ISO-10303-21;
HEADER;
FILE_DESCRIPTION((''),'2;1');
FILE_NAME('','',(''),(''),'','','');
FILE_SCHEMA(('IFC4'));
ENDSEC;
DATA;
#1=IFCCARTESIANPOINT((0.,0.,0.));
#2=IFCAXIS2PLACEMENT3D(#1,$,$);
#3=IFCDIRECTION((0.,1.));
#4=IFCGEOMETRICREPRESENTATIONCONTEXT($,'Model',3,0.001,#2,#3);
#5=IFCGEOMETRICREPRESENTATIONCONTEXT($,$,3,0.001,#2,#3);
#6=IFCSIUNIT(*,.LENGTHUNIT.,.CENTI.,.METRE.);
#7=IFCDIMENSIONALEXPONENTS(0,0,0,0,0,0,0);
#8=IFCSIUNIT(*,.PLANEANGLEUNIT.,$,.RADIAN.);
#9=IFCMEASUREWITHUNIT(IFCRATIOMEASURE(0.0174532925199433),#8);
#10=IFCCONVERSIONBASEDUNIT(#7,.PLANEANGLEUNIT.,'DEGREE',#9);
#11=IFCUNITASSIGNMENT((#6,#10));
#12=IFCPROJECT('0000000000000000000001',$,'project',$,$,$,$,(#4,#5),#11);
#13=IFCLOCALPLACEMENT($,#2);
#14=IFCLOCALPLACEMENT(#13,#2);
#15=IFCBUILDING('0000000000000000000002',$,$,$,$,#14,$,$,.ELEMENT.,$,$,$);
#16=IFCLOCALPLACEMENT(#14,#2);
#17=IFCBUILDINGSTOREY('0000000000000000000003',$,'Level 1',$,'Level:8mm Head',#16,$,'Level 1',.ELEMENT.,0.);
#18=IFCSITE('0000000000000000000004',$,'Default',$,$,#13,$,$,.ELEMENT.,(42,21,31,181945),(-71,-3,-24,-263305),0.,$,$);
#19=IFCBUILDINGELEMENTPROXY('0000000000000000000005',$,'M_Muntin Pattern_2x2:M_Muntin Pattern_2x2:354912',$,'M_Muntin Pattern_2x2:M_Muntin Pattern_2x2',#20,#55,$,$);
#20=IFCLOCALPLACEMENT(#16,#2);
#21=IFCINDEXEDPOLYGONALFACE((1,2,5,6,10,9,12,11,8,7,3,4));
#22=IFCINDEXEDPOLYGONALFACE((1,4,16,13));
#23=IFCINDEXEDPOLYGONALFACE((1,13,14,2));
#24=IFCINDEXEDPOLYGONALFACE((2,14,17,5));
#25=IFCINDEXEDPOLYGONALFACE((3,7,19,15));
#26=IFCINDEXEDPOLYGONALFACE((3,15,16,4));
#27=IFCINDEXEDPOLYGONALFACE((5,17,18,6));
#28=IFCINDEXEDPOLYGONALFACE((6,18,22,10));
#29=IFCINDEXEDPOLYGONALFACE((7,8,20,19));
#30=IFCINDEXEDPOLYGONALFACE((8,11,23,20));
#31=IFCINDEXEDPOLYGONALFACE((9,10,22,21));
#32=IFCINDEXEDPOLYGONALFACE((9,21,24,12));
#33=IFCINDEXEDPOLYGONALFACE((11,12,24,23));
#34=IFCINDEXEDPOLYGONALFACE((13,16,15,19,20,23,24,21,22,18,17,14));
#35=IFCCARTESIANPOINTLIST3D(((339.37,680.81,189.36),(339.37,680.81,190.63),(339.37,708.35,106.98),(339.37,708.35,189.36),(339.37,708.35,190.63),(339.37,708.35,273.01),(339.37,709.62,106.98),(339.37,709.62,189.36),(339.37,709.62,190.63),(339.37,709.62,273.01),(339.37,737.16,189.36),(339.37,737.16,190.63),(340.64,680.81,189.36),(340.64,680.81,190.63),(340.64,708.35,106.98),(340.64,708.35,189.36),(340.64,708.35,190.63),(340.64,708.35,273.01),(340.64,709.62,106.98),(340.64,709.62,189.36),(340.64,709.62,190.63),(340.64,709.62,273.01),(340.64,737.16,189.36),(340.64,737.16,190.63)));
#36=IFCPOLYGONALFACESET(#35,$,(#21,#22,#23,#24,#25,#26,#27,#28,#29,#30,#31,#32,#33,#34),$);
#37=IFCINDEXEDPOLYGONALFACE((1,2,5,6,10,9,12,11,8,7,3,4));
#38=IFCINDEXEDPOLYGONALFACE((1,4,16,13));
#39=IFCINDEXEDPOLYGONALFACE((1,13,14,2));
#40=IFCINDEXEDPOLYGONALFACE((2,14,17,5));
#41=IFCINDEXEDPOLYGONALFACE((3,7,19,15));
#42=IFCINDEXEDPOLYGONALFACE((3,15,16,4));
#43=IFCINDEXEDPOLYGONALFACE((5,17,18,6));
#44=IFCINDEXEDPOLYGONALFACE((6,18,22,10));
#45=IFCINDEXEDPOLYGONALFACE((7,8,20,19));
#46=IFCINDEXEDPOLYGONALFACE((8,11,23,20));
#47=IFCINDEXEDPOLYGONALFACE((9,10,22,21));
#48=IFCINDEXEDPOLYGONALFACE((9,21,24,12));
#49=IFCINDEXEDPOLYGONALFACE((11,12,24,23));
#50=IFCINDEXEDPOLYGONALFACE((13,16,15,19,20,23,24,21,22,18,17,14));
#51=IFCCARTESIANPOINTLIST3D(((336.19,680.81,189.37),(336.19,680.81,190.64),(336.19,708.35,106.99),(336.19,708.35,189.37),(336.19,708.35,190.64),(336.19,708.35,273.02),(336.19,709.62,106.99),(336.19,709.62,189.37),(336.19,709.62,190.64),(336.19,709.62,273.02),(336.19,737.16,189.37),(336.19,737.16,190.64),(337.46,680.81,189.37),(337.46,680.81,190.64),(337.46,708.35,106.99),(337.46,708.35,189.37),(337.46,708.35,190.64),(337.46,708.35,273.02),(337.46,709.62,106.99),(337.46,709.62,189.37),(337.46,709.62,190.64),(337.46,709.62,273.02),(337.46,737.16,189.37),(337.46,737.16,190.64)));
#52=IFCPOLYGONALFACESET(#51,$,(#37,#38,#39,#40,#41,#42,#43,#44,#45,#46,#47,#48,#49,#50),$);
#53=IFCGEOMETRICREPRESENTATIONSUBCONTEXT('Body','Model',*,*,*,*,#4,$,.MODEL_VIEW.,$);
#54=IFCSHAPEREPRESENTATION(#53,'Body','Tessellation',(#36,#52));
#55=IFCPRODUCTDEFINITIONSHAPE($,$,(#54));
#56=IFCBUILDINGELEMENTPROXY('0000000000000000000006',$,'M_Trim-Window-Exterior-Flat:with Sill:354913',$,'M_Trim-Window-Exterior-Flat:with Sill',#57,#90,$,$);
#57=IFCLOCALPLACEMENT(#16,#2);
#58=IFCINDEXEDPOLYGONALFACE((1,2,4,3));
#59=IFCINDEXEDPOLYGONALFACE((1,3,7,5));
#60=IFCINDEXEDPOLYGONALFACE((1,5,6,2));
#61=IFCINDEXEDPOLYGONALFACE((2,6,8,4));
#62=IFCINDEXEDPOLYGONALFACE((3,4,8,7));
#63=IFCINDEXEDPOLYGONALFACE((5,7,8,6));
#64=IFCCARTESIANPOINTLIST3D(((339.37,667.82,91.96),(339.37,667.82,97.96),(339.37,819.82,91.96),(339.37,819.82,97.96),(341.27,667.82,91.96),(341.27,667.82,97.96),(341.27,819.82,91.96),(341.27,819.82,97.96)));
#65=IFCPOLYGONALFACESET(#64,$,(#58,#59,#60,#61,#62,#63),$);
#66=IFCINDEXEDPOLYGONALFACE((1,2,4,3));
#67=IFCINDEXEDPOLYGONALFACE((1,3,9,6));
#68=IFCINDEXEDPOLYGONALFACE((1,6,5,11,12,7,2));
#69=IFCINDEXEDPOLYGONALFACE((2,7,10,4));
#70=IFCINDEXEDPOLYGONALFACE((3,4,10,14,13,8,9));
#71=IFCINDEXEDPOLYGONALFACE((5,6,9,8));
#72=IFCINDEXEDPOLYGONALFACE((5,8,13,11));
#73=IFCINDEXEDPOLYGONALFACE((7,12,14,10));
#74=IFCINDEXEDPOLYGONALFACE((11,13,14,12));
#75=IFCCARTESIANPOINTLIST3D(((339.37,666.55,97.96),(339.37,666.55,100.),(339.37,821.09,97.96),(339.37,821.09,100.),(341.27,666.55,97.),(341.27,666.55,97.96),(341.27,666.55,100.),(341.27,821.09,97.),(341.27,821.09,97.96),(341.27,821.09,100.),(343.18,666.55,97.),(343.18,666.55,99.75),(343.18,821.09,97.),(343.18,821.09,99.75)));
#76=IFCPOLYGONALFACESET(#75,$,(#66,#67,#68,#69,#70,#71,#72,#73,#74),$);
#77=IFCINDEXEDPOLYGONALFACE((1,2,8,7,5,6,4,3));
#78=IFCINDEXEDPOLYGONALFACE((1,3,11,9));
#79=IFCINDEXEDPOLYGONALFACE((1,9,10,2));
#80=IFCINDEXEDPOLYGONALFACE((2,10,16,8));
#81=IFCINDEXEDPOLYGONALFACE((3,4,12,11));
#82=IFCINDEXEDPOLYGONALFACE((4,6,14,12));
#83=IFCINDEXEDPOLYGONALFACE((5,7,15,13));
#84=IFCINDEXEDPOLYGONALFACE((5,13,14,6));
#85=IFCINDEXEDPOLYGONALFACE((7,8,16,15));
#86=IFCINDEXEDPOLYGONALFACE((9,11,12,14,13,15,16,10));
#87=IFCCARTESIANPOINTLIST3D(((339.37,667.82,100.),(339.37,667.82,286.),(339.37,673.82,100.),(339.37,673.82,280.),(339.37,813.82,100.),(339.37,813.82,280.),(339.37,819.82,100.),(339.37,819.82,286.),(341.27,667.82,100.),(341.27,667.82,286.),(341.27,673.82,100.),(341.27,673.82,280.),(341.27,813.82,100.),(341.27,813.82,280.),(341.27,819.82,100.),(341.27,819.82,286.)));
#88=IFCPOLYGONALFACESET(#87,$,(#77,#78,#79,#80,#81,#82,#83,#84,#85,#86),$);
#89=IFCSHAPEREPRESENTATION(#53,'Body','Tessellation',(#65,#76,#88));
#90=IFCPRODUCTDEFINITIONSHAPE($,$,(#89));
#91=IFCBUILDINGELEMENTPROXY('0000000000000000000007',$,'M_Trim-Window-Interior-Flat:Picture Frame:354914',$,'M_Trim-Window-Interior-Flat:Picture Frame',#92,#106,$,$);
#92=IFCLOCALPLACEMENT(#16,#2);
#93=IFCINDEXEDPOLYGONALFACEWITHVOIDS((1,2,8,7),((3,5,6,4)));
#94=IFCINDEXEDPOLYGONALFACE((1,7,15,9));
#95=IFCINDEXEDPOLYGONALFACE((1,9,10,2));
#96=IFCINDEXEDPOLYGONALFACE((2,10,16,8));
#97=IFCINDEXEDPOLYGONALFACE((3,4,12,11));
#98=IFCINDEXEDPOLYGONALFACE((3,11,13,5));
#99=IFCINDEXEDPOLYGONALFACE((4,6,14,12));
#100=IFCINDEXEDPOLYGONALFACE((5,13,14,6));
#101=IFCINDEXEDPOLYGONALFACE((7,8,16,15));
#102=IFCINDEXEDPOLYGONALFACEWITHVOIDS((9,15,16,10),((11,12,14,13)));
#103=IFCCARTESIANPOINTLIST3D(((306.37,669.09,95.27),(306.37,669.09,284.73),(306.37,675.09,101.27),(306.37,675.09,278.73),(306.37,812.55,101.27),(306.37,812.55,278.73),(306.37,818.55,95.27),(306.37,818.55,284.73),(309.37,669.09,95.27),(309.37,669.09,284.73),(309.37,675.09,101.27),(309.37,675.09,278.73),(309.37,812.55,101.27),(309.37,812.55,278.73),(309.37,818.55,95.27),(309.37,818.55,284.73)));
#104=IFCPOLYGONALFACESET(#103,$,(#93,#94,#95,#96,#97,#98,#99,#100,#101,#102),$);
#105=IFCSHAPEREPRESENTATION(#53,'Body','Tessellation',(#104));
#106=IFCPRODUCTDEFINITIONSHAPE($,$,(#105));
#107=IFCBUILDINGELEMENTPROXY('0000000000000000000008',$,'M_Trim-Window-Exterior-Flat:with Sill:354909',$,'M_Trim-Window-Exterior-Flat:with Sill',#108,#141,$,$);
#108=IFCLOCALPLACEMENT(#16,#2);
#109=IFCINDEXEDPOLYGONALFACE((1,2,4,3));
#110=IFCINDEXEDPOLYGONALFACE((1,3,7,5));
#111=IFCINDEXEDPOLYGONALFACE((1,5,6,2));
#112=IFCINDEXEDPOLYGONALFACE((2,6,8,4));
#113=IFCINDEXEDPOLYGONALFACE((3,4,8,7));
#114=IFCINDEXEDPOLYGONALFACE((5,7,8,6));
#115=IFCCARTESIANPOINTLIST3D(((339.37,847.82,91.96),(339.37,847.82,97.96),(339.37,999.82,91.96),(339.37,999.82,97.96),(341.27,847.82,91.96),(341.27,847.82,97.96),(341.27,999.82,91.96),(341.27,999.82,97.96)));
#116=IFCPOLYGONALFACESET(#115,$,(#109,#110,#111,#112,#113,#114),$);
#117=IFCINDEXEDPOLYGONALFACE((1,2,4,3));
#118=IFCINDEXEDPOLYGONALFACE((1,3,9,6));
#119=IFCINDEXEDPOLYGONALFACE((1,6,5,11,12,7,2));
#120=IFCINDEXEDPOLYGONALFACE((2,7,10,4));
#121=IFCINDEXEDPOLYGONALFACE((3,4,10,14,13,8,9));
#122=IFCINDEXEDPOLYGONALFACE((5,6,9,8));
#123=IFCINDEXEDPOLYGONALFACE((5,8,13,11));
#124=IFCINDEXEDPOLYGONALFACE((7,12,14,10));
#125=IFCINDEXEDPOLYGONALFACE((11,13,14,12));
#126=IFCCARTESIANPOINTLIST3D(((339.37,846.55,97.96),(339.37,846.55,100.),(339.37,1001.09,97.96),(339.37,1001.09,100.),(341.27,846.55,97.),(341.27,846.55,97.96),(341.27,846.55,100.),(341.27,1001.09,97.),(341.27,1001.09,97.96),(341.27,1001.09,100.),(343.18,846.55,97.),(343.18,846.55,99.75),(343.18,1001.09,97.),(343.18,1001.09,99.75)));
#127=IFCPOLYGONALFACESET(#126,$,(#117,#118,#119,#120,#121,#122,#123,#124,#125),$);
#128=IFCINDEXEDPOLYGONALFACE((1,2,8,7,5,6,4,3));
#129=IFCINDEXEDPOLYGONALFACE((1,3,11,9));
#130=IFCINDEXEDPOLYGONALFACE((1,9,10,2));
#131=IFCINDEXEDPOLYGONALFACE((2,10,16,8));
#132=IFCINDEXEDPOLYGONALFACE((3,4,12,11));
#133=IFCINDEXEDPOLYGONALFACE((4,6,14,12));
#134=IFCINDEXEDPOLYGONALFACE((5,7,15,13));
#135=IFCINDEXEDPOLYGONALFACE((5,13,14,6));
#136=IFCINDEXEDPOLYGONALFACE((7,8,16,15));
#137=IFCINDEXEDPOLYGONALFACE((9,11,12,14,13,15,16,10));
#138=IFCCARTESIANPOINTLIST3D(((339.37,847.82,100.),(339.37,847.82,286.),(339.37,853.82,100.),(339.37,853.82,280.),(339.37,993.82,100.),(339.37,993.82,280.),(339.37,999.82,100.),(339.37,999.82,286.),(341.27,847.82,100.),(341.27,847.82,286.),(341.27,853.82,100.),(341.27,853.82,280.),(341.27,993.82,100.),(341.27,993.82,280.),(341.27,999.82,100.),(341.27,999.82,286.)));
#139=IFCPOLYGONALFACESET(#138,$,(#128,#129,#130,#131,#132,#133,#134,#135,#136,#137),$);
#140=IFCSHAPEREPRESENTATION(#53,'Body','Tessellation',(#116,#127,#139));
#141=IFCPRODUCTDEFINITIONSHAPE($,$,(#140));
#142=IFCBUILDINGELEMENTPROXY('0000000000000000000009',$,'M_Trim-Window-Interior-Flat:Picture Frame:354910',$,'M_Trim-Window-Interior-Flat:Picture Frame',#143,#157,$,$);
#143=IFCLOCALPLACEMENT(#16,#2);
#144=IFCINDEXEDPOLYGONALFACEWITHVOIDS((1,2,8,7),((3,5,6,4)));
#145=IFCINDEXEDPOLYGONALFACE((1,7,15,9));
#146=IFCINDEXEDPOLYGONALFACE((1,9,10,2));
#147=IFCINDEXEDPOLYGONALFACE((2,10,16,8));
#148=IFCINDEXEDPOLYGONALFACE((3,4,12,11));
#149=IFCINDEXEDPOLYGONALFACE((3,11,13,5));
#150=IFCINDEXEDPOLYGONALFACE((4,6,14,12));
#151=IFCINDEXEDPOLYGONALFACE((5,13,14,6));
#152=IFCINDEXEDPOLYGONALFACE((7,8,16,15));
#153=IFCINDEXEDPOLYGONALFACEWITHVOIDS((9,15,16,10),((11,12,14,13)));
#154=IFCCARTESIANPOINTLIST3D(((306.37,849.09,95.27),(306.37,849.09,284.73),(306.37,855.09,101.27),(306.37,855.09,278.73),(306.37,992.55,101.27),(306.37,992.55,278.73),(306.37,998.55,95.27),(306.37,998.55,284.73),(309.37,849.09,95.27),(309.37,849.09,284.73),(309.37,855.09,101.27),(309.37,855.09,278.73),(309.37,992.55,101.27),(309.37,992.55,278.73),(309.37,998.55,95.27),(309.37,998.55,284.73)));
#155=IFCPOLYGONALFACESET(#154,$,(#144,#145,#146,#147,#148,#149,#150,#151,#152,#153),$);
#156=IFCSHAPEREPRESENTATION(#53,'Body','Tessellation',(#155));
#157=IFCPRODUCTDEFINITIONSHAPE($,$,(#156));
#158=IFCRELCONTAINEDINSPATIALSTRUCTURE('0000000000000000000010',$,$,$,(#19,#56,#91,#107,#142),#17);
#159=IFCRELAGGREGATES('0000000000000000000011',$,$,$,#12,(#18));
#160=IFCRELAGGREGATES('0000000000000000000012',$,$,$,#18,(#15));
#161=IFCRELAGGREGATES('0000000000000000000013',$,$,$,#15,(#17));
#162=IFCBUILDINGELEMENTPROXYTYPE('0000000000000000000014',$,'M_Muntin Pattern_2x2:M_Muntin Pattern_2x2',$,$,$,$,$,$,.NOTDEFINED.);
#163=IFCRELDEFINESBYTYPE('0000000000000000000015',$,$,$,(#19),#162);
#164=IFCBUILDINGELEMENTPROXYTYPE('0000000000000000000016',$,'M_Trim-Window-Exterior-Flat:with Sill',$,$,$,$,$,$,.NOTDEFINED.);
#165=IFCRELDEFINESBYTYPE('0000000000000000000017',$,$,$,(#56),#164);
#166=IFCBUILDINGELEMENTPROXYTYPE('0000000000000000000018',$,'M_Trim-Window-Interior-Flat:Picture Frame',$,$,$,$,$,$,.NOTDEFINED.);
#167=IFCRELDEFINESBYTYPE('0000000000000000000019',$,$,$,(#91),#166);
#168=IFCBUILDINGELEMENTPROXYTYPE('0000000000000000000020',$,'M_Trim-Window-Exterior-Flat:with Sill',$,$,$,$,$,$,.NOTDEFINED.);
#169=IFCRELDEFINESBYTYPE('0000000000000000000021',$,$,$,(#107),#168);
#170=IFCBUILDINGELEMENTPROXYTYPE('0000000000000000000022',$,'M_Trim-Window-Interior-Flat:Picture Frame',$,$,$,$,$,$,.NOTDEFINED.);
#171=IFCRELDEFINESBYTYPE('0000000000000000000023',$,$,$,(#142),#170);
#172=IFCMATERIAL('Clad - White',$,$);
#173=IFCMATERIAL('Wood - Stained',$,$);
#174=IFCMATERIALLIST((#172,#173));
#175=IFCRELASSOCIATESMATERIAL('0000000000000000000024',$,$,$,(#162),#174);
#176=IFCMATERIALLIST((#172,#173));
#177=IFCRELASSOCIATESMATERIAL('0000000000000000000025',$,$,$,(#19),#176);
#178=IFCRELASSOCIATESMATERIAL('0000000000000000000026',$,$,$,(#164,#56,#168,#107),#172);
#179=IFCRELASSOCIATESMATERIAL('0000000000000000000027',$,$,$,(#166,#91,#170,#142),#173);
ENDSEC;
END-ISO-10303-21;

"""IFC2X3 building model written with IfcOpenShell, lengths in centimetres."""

from ifc_helpers import new_model, entity, si_unit, converted_unit, direction, frame, frame_2d, origin, place, context, subcontext, project, spatial, polyline, rectangle, outline, extrude, source, transform, mapped, material, material_list, type_object, type_shapes, element, save


model = new_model("IFC2X3")

# Units and contexts
model_context = context("Model", 3, precision=0.001, world=origin(), true_north=direction((0.0, 1.0)))
context_of_model = context(None, 3, precision=0.001, world=origin(), true_north=direction((0.0, 1.0)))
body_context = subcontext(model_context, "Body", "Model", "MODEL_VIEW")
ifc_project = project(units=[si_unit("LENGTHUNIT", "METRE", prefix="CENTI"), converted_unit("PLANEANGLEUNIT", "DEGREE", entity("IfcRatioMeasure", 0.0174532925199433), si_unit("PLANEANGLEUNIT", "RADIAN"), dimensions=[0, 0, 0, 0, 0, 0, 0])], contexts=[model_context, context_of_model])

# Site, building, storey
site_placement = place(None, origin())
site = spatial("IfcSite", under=ifc_project, at=site_placement, Name="Default", CompositionType="ELEMENT", RefLatitude=(42, 21, 31, 181945), RefLongitude=(-71, -3, -24, -263305), RefElevation=0.0)
building_placement = place(site_placement, origin())
building = spatial("IfcBuilding", under=site, at=building_placement, CompositionType="ELEMENT")
storey_placement = place(building_placement, origin())
storey = spatial("IfcBuildingStorey", under=building, at=storey_placement, Name="Level 1", ObjectType="Level:8mm Head", LongName="Level 1", CompositionType="ELEMENT", Elevation=0.0)

# Shared definitions
ifc_material_1 = material(Name="Wood - Stained")
ifc_material_2 = material(Name="Clad - White")

# Building element proxies
ifc_material_list_1 = material_list([ifc_material_2, ifc_material_1])
building_element_proxy_type_1 = type_object("IfcBuildingElementProxyType", Name="M_Muntin Pattern_2x2:M_Muntin Pattern_2x2", PredefinedType="NOTDEFINED", material=ifc_material_list_1)
shared_shape_1 = source(origin(), body_context, "Body", "SweptSolid", [
    extrude(outline(polyline([(0.64, -0.64), (83.01, -0.64), (83.01, 0.63), (0.64, 0.63), (0.64, 28.17), (-0.63, 28.17), (-0.63, 0.63), (-83.02, 0.63), (-83.02, -0.64), (-0.63, -0.64), (-0.63, -28.17), (0.64, -28.17), (0.64, -0.64)])), frame((0.0, -2.22, 83.01), z_axis=(0.0, 1.0, 0.0), x_axis=(0.0, 0.0, 1.0)), (0.0, 0.0, 1.0), 1.27),
    extrude(outline(polyline([(0.64, -0.64), (83.02, -0.64), (83.02, 0.63), (0.64, 0.63), (0.64, 28.17), (-0.63, 28.17), (-0.63, 0.63), (-83.02, 0.63), (-83.02, -0.64), (-0.63, -0.64), (-0.63, -28.17), (0.64, -28.17), (0.64, -0.64)])), frame((0.0, 0.95, 83.02), z_axis=(0.0, 1.0, 0.0), x_axis=(0.0, 0.0, 1.0)), (0.0, 0.0, 1.0), 1.27),
])
type_shapes(building_element_proxy_type_1, [shared_shape_1])
ifc_material_list_2 = material_list([ifc_material_2, ifc_material_1])
proxy_1_placement = place(storey_placement, frame((338.41, 708.98, 106.99), z_axis=(0.0, 0.0, 1.0), x_axis=(0.0, 1.0, 0.0)))
element("IfcBuildingElementProxy", 1, at=proxy_1_placement, inside=storey, type_object=building_element_proxy_type_1, material=ifc_material_list_2, Name="M_Muntin Pattern_2x2:M_Muntin Pattern_2x2:354912", ObjectType="M_Muntin Pattern_2x2:M_Muntin Pattern_2x2", context=body_context, shape_type="MappedRepresentation", body=[
    mapped(shared_shape_1, transform((0.0, 0.0, 0.0), scale=1.0)),
])
building_element_proxy_type_2 = type_object("IfcBuildingElementProxyType", Name="M_Trim-Window-Exterior-Flat:with Sill", PredefinedType="NOTDEFINED", material=ifc_material_2)
shared_shape_2 = source(origin(), body_context, "Body", "SweptSolid", [
    extrude(rectangle(XDim=152.0, YDim=6.0, at=frame_2d((0.0, 0.0), x_axis=(1.0, 0.0))), frame((0.0, -185.04, 0.0), z_axis=(0.0, 0.0, 1.0), x_axis=(-1.0, 0.0, 0.0)), (0.0, 0.0, 1.0), 1.91),
    extrude(outline(polyline([(-1.9, -1.52), (0.0, -1.52), (0.0, -0.57), (1.9, -0.57), (1.9, 1.48), (0.0, 1.48), (-1.9, 1.23), (-1.9, -1.52)])), frame((-77.27, -181.48, 1.9), z_axis=(1.0, 0.0, 0.0), x_axis=(0.0, 0.0, -1.0)), (0.0, 0.0, 1.0), 154.54),
    extrude(outline(polyline([(-94.5, -76.0), (91.5, -76.0), (91.5, -70.0), (-88.5, -70.0), (-88.5, 70.0), (91.5, 70.0), (91.5, 76.0), (-94.5, 76.0), (-94.5, -76.0)])), frame((0.0, -88.5, 0.0), z_axis=(0.0, 0.0, 1.0), x_axis=(0.0, -1.0, 0.0)), (0.0, 0.0, 1.0), 1.91),
])
type_shapes(building_element_proxy_type_2, [shared_shape_2])
proxy_2_placement = place(storey_placement, frame((339.37, 743.82, 280.0), z_axis=(1.0, 0.0, 0.0), x_axis=(0.0, 1.0, 0.0)))
element("IfcBuildingElementProxy", 2, at=proxy_2_placement, inside=storey, type_object=building_element_proxy_type_2, material=ifc_material_2, Name="M_Trim-Window-Exterior-Flat:with Sill:354913", ObjectType="M_Trim-Window-Exterior-Flat:with Sill", context=body_context, shape_type="MappedRepresentation", body=[
    mapped(shared_shape_2, transform((0.0, 0.0, 0.0), scale=1.0)),
])
building_element_proxy_type_3 = type_object("IfcBuildingElementProxyType", Name="M_Trim-Window-Interior-Flat:Picture Frame", PredefinedType="NOTDEFINED", material=ifc_material_1)
shared_shape_3 = source(origin(), body_context, "Body", "SweptSolid", [
    extrude(outline(polyline([(-74.73, -94.73), (74.73, -94.73), (74.73, 94.73), (-74.73, 94.73), (-74.73, -94.73)]), holes=[polyline([(-68.73, -88.73), (-68.73, 88.73), (68.73, 88.73), (68.73, -88.73), (-68.73, -88.73)])]), frame((0.0, -90.0, 0.0), z_axis=(0.0, 0.0, 1.0), x_axis=(-1.0, 0.0, 0.0)), (0.0, 0.0, 1.0), 3.0),
])
type_shapes(building_element_proxy_type_3, [shared_shape_3])
proxy_3_placement = place(storey_placement, frame((309.37, 743.82, 280.0), z_axis=(-1.0, 0.0, 0.0), x_axis=(0.0, -1.0, 0.0)))
element("IfcBuildingElementProxy", 3, at=proxy_3_placement, inside=storey, type_object=building_element_proxy_type_3, material=ifc_material_1, Name="M_Trim-Window-Interior-Flat:Picture Frame:354914", ObjectType="M_Trim-Window-Interior-Flat:Picture Frame", context=body_context, shape_type="MappedRepresentation", body=[
    mapped(shared_shape_3, transform((0.0, 0.0, 0.0), scale=1.0)),
])
building_element_proxy_type_4 = type_object("IfcBuildingElementProxyType", Name="M_Trim-Window-Exterior-Flat:with Sill", PredefinedType="NOTDEFINED", material=ifc_material_2)
shared_shape_4 = source(origin(), body_context, "Body", "SweptSolid", [
    extrude(rectangle(XDim=6.0, YDim=152.0, at=frame_2d((0.0, 0.0), x_axis=(1.0, 0.0))), frame((0.0, 185.04, 0.0), z_axis=(0.0, 0.0, 1.0), x_axis=(0.0, 1.0, 0.0)), (0.0, 0.0, 1.0), 1.91),
    extrude(outline(polyline([(-1.52, -1.9), (1.23, -1.9), (1.48, 0.0), (1.48, 1.9), (-0.57, 1.9), (-0.57, 0.0), (-1.52, 0.0), (-1.52, -1.9)])), frame((-77.27, 181.48, 1.9), z_axis=(1.0, 0.0, 0.0), x_axis=(0.0, -1.0, 0.0)), (0.0, 0.0, 1.0), 154.54),
    extrude(outline(polyline([(-76.0, -94.5), (76.0, -94.5), (76.0, 91.5), (70.0, 91.5), (70.0, -88.5), (-70.0, -88.5), (-70.0, 91.5), (-76.0, 91.5), (-76.0, -94.5)])), frame((0.0, 88.5, 0.0)), (0.0, 0.0, 1.0), 1.91),
])
type_shapes(building_element_proxy_type_4, [shared_shape_4])
proxy_4_placement = place(storey_placement, frame((339.37, 923.82, 280.0), z_axis=(1.0, 0.0, 0.0), x_axis=(0.0, -1.0, 0.0)))
element("IfcBuildingElementProxy", 4, at=proxy_4_placement, inside=storey, type_object=building_element_proxy_type_4, material=ifc_material_2, Name="M_Trim-Window-Exterior-Flat:with Sill:354909", ObjectType="M_Trim-Window-Exterior-Flat:with Sill", context=body_context, shape_type="MappedRepresentation", body=[
    mapped(shared_shape_4, transform((0.0, 0.0, 0.0), scale=1.0)),
])
building_element_proxy_type_5 = type_object("IfcBuildingElementProxyType", Name="M_Trim-Window-Interior-Flat:Picture Frame", PredefinedType="NOTDEFINED", material=ifc_material_1)
shared_shape_5 = source(origin(), body_context, "Body", "SweptSolid", [
    extrude(outline(polyline([(-94.73, -74.73), (94.73, -74.73), (94.73, 74.73), (-94.73, 74.73), (-94.73, -74.73)]), holes=[polyline([(-88.73, -68.73), (-88.73, 68.73), (88.73, 68.73), (88.73, -68.73), (-88.73, -68.73)])]), frame((0.0, 90.0, 0.0), z_axis=(0.0, 0.0, 1.0), x_axis=(0.0, 1.0, 0.0)), (0.0, 0.0, 1.0), 3.0),
])
type_shapes(building_element_proxy_type_5, [shared_shape_5])
proxy_5_placement = place(storey_placement, frame((309.37, 923.82, 280.0), z_axis=(-1.0, 0.0, 0.0), x_axis=(0.0, 1.0, 0.0)))
element("IfcBuildingElementProxy", 5, at=proxy_5_placement, inside=storey, type_object=building_element_proxy_type_5, material=ifc_material_1, Name="M_Trim-Window-Interior-Flat:Picture Frame:354910", ObjectType="M_Trim-Window-Interior-Flat:Picture Frame", context=body_context, shape_type="MappedRepresentation", body=[
    mapped(shared_shape_5, transform((0.0, 0.0, 0.0), scale=1.0)),
])

save(model, "model.ifc")
